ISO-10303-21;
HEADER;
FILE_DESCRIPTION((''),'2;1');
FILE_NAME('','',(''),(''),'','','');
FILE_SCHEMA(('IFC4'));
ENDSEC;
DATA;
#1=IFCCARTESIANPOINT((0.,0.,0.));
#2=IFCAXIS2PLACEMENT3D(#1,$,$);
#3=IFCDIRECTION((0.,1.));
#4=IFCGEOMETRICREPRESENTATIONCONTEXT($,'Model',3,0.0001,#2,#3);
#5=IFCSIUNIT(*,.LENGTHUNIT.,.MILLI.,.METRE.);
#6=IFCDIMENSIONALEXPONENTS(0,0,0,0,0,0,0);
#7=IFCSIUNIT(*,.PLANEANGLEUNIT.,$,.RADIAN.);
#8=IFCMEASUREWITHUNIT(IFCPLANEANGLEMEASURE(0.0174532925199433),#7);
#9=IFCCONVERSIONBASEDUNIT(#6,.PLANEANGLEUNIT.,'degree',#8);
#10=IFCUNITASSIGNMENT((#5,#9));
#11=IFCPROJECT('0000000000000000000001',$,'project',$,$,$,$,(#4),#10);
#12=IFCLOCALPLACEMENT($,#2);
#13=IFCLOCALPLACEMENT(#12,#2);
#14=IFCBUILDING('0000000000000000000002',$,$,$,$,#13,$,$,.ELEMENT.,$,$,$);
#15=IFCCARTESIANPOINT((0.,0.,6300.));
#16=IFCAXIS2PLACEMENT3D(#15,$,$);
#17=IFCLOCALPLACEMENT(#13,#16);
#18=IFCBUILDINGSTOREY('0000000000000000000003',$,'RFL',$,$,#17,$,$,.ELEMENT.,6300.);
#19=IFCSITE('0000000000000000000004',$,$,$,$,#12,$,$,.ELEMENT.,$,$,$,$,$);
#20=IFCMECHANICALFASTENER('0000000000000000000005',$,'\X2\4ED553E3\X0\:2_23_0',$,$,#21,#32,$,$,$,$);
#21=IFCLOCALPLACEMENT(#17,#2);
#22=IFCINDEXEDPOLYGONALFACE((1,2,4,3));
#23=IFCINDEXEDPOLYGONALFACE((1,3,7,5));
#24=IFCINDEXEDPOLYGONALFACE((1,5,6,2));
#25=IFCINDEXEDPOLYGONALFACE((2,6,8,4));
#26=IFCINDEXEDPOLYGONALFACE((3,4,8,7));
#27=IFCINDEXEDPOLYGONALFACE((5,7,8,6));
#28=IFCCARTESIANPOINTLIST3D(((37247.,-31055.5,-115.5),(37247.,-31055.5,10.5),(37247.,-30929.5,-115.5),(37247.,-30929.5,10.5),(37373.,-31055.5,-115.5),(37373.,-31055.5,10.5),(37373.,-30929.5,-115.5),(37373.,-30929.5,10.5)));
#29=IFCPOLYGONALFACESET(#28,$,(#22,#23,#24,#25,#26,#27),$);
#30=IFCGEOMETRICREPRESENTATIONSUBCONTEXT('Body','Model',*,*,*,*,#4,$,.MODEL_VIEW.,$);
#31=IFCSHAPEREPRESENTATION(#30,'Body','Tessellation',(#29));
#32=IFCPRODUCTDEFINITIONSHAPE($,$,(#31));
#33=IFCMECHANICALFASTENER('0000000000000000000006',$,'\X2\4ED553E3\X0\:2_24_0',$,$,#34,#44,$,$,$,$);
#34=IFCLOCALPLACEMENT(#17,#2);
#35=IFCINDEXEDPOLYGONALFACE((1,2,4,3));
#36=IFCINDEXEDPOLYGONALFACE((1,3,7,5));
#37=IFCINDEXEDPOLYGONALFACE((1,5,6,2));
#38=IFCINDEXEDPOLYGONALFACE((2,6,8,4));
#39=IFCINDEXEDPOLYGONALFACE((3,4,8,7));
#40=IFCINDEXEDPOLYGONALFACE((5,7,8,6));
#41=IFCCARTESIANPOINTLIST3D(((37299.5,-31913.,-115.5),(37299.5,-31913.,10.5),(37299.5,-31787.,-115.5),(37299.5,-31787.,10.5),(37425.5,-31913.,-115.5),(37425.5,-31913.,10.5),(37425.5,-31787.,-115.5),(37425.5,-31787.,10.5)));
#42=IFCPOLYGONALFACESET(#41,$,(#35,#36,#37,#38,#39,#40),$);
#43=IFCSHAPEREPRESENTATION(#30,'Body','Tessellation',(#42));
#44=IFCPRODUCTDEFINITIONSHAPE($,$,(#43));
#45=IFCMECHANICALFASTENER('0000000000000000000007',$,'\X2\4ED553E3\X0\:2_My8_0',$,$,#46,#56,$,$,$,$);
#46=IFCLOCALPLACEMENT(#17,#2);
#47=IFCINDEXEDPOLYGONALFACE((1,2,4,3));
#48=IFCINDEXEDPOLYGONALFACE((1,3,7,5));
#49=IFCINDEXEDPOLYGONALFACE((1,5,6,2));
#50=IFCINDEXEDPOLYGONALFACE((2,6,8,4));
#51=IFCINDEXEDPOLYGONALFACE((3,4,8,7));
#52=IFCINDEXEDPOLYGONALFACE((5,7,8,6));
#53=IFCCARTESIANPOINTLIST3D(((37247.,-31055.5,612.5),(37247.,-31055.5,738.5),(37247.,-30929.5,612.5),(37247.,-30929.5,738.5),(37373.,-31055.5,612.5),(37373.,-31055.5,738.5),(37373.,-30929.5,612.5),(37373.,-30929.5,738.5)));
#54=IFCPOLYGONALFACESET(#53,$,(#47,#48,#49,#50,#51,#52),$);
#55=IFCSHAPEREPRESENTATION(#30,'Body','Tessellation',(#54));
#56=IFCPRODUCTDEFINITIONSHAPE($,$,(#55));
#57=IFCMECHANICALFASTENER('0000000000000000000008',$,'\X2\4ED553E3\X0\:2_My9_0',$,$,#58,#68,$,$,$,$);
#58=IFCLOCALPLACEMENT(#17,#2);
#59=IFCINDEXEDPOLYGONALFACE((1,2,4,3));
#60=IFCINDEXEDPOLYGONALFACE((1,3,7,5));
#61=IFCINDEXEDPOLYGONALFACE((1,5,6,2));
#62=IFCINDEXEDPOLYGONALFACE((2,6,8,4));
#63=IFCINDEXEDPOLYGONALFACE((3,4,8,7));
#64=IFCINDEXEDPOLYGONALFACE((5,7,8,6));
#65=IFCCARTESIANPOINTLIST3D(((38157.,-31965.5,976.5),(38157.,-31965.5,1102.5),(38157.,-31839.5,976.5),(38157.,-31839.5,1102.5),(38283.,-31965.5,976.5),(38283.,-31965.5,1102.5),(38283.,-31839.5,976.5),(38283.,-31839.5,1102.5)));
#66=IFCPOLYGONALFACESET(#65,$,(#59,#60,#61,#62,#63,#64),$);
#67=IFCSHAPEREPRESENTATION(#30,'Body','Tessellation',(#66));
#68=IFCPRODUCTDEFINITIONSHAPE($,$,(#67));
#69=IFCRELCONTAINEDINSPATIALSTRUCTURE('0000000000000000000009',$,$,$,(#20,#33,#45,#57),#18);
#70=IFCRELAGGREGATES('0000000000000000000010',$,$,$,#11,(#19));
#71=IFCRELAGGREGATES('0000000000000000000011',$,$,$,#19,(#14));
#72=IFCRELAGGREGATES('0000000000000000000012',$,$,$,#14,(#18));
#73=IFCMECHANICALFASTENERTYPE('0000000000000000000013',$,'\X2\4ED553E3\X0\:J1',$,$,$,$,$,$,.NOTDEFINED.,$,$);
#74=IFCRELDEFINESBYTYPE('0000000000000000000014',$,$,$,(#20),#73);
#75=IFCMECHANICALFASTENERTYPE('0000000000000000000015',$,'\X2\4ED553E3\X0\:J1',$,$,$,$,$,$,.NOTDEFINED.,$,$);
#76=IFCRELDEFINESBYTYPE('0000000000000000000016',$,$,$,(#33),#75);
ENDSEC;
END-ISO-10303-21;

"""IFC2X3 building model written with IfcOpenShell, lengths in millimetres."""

from ifc_helpers import new_model, entity, si_unit, converted_unit, direction, frame, origin, origin_with_axes, origin_2d, place, context, subcontext, project, spatial, rectangle, extrude, type_object, element, save


model = new_model("IFC2X3")

# Units and contexts
model_context = context("Model", 3, precision=0.0001, world=origin(), true_north=direction((0.0, 1.0)))
body_context = subcontext(model_context, "Body", "Model", "MODEL_VIEW")
ifc_project = project(units=[si_unit("LENGTHUNIT", "METRE", prefix="MILLI"), converted_unit("PLANEANGLEUNIT", "degree", entity("IfcPlaneAngleMeasure", 0.0174532925199433), si_unit("PLANEANGLEUNIT", "RADIAN"), dimensions=[0, 0, 0, 0, 0, 0, 0])], contexts=[model_context])

# Site, building, storey
site_placement = place(None, origin())
site = spatial("IfcSite", under=ifc_project, at=site_placement, CompositionType="ELEMENT")
building_placement = place(site_placement, origin())
building = spatial("IfcBuilding", under=site, at=building_placement, CompositionType="ELEMENT")
storey_placement = place(building_placement, frame((0.0, 0.0, 6300.0)))
storey = spatial("IfcBuildingStorey", under=building, at=storey_placement, Name="RFL", CompositionType="ELEMENT", Elevation=6300.0)

# Mechanical fasteners
mechanical_fastener_type_1 = type_object("IfcMechanicalFastenerType", Name="仕口:J1")
mechanical_fastener_1_placement = place(storey_placement, frame((37310.0, -30992.5, -115.5)))
element("IfcMechanicalFastener", 1, at=mechanical_fastener_1_placement, inside=storey, type_object=mechanical_fastener_type_1, Name="仕口:2_23_0", context=body_context, shape_type="SweptSolid", body=[
    extrude(rectangle(XDim=126.0, YDim=126.0, at=origin_2d()), origin_with_axes(), (0.0, 0.0, 1.0), 126.0),
])
mechanical_fastener_type_2 = type_object("IfcMechanicalFastenerType", Name="仕口:J1")
mechanical_fastener_2_placement = place(storey_placement, frame((37362.5, -31850.0, -115.5)))
element("IfcMechanicalFastener", 2, at=mechanical_fastener_2_placement, inside=storey, type_object=mechanical_fastener_type_2, Name="仕口:2_24_0", context=body_context, shape_type="SweptSolid", body=[
    extrude(rectangle(XDim=126.0, YDim=126.0, at=origin_2d()), origin_with_axes(), (0.0, 0.0, 1.0), 126.0),
])
for number, where, name in (
    (3, (37310.0, -30992.5, 612.5), "仕口:2_My8_0"),
    (4, (38220.0, -31902.5, 976.5), "仕口:2_My9_0"),
):
    element("IfcMechanicalFastener", number, at=place(storey_placement, frame(where)), inside=storey, Name=name, context=body_context, shape_type="SweptSolid", body=[
        extrude(rectangle(XDim=126.0, YDim=126.0, at=origin_2d()), origin_with_axes(), (0.0, 0.0, 1.0), 126.0),
    ])

save(model, "model.ifc")
